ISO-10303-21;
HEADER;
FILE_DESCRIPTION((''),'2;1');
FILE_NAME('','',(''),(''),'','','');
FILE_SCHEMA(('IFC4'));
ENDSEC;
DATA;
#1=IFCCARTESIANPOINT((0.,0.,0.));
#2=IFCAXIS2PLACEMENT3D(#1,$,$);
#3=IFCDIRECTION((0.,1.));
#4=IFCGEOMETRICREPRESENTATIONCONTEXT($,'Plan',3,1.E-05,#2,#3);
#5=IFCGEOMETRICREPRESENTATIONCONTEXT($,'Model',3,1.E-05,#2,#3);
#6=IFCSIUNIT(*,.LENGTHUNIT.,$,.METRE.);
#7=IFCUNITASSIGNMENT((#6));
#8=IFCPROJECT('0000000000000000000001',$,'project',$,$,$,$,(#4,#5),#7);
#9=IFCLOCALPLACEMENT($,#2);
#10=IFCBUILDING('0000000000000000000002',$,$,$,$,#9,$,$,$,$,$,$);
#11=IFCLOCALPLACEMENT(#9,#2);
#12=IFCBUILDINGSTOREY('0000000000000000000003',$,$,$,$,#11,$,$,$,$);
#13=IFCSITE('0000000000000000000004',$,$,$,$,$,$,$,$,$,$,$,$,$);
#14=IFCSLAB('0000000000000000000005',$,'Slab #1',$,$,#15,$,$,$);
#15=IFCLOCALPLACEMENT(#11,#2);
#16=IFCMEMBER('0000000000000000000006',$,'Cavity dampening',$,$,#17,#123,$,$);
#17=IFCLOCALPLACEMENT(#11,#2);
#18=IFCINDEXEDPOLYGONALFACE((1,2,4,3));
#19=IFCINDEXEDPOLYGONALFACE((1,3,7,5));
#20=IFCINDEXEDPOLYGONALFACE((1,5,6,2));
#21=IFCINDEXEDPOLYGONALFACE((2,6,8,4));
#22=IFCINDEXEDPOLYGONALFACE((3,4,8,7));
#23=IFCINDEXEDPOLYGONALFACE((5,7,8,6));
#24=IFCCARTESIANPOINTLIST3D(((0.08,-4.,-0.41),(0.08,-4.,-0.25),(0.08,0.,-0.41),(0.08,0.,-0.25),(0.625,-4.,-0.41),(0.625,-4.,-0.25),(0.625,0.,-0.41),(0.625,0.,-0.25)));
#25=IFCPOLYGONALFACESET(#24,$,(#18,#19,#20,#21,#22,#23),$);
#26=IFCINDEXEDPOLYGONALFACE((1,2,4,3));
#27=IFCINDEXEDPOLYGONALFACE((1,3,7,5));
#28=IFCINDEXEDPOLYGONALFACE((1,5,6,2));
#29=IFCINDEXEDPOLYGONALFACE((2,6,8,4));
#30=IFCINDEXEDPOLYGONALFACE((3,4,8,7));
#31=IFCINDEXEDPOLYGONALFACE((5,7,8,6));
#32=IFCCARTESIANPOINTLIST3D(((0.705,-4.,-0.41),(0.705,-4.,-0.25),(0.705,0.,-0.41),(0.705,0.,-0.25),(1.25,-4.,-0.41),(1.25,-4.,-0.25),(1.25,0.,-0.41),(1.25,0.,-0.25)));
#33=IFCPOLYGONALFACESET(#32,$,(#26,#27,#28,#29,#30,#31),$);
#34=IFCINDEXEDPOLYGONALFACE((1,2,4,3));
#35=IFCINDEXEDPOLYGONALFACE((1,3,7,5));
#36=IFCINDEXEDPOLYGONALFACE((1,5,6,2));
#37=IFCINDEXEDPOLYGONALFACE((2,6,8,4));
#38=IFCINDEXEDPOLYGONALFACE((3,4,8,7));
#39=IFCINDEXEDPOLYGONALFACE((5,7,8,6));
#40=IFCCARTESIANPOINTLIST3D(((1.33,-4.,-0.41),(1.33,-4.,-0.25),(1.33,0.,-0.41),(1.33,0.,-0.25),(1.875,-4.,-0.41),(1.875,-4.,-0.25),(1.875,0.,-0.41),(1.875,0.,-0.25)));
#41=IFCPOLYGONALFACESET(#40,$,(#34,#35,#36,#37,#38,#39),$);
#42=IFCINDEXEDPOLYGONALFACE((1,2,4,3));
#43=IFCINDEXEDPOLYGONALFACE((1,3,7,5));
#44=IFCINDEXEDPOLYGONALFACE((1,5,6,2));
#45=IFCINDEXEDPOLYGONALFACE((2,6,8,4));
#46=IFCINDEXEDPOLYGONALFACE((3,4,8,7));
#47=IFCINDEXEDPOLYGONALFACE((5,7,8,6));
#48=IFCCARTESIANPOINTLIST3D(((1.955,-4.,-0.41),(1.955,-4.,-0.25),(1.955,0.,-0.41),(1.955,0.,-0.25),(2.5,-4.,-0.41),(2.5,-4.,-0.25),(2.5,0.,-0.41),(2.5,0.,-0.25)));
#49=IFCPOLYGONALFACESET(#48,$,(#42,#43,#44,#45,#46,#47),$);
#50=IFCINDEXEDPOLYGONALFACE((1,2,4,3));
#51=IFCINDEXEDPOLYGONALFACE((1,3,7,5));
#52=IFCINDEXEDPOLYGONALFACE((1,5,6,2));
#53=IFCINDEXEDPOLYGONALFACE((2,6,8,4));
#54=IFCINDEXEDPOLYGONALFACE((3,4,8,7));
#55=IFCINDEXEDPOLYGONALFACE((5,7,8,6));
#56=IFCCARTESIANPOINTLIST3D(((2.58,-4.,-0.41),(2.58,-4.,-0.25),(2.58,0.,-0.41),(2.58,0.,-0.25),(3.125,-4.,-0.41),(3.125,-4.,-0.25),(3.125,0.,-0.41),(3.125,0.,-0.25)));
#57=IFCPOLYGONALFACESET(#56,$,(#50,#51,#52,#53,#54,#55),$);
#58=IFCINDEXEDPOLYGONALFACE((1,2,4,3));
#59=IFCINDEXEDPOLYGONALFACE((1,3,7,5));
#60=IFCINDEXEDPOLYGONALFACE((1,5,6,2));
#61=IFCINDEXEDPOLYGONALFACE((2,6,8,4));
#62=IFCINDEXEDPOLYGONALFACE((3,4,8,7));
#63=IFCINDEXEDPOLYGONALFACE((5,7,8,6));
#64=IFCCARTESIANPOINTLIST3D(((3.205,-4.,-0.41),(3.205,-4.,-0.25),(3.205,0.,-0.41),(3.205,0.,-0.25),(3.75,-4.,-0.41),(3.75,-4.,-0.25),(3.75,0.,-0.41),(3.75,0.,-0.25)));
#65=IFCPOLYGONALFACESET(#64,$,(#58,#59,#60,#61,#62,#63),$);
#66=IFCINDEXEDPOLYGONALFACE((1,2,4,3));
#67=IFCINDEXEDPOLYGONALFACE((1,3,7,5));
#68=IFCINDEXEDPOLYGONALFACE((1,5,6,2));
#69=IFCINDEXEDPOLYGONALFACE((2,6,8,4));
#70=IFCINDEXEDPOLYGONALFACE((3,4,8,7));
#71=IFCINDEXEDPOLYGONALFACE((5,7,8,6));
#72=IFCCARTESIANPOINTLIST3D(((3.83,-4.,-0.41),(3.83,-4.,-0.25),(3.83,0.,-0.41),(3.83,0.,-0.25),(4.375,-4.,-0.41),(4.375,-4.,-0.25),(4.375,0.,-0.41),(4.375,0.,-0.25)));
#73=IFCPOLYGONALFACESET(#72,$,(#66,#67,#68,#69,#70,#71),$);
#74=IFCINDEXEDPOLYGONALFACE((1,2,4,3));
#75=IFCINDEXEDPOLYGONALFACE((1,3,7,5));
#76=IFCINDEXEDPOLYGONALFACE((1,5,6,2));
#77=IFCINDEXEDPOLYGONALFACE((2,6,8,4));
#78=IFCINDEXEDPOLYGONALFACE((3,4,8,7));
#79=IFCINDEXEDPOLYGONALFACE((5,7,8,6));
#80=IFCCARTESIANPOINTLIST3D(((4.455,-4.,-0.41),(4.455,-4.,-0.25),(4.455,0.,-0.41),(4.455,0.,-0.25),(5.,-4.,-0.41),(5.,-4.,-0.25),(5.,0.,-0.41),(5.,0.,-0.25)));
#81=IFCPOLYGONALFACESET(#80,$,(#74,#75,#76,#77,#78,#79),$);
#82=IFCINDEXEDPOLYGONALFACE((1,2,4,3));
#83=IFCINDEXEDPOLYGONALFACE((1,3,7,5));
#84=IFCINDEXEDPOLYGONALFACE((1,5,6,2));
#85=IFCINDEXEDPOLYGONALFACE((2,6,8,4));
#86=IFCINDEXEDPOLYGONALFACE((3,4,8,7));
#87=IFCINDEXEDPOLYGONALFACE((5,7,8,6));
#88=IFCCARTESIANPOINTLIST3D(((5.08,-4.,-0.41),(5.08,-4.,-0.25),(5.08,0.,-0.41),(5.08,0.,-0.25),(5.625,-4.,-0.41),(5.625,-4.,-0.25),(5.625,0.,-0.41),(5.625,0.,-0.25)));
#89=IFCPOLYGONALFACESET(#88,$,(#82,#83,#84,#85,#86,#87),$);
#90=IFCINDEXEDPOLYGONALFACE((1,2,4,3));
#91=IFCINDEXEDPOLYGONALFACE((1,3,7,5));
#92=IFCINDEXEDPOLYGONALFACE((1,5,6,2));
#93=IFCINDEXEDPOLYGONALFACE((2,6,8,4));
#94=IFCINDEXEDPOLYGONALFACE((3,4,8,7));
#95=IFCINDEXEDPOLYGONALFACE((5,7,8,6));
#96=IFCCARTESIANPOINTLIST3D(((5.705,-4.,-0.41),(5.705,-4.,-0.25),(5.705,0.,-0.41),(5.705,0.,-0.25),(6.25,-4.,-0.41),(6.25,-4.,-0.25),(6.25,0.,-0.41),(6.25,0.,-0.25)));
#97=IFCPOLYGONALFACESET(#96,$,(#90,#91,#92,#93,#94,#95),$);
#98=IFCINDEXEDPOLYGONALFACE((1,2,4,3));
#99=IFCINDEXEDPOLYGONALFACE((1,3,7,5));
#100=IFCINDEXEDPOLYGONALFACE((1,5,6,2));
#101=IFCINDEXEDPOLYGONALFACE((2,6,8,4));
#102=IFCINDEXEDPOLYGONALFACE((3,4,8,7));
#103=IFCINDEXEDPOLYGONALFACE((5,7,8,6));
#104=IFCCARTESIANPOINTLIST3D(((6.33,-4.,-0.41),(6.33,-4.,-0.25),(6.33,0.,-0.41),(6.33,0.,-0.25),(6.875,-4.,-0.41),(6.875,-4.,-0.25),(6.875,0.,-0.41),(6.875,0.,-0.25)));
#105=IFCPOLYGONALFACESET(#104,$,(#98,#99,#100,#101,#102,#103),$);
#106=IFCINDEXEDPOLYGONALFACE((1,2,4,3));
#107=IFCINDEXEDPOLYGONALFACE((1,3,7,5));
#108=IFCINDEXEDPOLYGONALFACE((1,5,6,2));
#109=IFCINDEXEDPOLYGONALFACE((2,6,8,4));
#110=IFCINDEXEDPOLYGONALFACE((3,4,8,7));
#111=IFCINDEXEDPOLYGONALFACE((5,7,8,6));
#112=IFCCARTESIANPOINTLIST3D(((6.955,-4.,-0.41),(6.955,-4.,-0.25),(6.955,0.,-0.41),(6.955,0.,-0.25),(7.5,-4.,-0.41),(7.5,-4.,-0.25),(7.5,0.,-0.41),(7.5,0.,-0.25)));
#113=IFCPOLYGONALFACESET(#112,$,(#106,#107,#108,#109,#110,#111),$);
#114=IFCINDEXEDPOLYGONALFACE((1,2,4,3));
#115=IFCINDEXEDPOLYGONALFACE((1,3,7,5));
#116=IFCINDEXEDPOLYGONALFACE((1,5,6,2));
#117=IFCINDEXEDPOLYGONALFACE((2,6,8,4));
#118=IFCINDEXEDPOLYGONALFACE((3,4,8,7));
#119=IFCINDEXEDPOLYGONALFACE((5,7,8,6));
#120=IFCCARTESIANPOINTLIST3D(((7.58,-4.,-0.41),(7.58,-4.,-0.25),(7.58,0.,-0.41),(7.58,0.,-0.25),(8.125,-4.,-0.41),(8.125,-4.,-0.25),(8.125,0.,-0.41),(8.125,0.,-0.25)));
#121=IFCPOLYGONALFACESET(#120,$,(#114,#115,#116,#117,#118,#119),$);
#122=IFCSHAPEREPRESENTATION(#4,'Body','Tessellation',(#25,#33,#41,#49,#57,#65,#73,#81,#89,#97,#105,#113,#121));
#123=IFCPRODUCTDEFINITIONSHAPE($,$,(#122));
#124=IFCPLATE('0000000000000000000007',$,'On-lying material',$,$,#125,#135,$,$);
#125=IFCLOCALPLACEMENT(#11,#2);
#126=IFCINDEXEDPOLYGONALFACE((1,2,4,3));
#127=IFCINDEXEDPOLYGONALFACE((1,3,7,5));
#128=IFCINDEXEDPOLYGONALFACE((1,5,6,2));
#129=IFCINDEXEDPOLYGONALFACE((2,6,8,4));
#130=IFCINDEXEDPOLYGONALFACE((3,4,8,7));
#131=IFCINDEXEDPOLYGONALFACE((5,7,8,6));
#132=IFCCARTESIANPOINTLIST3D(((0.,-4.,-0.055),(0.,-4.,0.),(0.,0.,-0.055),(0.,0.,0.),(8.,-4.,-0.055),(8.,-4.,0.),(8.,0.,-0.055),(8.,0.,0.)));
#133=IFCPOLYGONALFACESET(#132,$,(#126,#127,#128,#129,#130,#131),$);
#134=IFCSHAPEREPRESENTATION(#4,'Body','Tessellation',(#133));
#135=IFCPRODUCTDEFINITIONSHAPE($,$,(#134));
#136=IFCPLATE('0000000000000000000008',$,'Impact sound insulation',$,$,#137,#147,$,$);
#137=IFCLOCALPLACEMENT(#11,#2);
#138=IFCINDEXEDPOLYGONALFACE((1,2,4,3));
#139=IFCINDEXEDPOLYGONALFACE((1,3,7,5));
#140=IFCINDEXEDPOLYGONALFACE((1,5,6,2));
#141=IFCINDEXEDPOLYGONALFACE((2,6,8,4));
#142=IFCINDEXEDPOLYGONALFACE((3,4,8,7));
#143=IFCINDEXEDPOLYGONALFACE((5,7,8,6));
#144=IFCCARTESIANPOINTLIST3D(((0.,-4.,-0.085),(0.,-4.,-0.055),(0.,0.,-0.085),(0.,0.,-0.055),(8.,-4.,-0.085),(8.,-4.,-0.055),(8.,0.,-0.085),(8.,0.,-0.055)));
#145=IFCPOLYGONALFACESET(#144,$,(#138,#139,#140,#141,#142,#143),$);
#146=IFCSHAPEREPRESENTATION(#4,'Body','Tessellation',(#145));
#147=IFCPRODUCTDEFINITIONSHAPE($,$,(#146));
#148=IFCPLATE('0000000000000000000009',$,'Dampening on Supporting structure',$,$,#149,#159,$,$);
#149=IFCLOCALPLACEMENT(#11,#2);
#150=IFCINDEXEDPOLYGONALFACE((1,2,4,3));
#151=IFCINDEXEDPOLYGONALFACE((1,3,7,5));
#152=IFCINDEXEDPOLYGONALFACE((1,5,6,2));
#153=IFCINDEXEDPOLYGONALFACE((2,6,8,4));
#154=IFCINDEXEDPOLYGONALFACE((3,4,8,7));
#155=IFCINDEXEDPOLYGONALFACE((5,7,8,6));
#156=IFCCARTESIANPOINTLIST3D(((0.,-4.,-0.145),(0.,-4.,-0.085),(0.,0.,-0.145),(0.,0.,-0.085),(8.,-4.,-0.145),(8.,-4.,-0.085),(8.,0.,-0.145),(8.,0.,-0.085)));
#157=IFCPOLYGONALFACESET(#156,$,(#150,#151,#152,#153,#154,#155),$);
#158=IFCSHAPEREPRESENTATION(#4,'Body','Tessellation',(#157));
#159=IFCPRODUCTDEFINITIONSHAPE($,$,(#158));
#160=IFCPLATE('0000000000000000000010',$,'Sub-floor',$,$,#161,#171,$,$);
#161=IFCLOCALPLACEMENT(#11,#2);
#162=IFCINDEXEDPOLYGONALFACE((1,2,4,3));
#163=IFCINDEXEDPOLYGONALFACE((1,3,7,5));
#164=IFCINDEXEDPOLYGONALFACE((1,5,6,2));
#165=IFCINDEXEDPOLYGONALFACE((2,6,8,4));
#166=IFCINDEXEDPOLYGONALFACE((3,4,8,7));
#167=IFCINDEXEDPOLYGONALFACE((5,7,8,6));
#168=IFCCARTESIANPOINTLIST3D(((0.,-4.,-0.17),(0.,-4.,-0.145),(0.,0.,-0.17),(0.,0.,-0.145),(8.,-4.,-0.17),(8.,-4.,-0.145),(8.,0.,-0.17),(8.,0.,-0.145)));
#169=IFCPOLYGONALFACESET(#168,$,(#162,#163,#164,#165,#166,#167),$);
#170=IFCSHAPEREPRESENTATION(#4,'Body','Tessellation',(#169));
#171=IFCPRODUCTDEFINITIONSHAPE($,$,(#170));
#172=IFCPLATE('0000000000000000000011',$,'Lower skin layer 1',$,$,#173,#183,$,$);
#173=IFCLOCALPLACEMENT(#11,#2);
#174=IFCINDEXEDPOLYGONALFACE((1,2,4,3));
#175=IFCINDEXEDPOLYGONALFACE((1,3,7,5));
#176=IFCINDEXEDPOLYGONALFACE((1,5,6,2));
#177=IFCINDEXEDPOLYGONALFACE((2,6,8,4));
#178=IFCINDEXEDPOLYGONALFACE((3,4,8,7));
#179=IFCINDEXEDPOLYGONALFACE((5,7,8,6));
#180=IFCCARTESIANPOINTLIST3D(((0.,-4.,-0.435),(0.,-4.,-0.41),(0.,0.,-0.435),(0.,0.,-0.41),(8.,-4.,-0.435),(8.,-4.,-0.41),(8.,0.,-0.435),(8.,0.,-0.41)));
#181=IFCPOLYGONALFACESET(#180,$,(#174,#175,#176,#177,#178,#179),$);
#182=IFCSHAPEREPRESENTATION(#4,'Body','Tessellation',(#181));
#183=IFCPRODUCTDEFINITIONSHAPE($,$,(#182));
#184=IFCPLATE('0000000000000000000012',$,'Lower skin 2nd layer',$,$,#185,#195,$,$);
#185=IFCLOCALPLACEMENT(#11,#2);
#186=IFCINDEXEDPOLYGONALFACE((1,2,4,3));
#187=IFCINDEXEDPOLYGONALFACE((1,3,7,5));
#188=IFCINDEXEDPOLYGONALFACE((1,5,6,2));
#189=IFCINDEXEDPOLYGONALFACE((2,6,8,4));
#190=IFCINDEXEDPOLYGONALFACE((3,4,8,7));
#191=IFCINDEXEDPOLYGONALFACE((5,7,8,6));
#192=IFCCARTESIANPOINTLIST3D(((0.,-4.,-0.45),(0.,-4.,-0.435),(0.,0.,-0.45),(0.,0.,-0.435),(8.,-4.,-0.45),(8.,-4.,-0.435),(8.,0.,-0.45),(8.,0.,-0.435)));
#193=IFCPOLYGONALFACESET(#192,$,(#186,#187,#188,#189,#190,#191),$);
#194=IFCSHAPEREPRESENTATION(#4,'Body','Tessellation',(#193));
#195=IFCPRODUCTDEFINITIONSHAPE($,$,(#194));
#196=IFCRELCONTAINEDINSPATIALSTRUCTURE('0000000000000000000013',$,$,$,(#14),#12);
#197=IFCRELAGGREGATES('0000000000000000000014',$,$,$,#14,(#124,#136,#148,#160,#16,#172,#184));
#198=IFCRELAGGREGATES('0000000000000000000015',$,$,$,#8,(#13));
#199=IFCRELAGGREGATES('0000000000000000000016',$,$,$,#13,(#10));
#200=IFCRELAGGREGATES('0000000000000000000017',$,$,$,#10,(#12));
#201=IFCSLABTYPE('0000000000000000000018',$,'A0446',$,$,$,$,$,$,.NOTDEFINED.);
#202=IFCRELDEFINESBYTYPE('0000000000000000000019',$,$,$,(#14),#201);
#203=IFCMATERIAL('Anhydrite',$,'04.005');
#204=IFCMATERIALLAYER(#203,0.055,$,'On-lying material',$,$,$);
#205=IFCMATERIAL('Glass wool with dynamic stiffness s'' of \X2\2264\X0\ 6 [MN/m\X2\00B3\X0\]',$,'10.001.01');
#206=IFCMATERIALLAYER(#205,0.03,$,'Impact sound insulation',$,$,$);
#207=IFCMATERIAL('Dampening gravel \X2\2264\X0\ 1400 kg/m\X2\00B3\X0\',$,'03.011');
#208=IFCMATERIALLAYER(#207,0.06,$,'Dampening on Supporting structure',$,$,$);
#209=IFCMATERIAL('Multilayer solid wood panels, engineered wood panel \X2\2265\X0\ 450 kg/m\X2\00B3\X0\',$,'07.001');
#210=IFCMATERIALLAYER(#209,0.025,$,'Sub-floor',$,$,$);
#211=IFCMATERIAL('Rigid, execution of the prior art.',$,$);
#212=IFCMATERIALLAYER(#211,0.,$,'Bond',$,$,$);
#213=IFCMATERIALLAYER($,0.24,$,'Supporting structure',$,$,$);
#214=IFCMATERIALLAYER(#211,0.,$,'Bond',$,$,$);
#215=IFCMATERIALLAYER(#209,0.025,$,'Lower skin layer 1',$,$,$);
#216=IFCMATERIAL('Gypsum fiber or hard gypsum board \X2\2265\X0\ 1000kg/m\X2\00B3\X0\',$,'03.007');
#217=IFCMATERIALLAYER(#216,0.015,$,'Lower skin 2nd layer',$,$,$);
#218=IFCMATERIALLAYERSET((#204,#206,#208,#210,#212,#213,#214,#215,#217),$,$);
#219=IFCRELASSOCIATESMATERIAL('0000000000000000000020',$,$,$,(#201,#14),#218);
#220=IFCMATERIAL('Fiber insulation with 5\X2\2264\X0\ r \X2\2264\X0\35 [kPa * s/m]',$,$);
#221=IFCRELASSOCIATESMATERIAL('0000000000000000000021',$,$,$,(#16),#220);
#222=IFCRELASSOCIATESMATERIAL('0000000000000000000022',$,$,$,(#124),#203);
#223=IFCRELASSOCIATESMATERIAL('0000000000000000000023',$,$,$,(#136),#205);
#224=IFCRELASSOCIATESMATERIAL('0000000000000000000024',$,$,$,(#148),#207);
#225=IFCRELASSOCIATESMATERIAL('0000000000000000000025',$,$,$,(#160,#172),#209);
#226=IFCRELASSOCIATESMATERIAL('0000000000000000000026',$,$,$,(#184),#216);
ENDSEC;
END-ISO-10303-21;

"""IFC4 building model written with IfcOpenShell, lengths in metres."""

from ifc_helpers import new_model, si_unit, direction, frame, frame_2d, origin, origin_with_axes, place, context, project, spatial, rectangle, extrude, material, layer, layer_set, type_object, element, aggregate, save


model = new_model("IFC4")

# Units and contexts
plan_context = context("Plan", 3, precision=1e-05, world=origin(), true_north=direction((0.0, 1.0)))
model_context = context("Model", 3, precision=1e-05, world=origin(), true_north=direction((0.0, 1.0)))
ifc_project = project(units=[si_unit("LENGTHUNIT", "METRE")], contexts=[plan_context, model_context])

# Site, building, storey
site = spatial("IfcSite", under=ifc_project)
building_placement = place(None, origin())
building = spatial("IfcBuilding", under=site, at=building_placement)
storey_placement = place(building_placement, origin())
storey = spatial("IfcBuildingStorey", under=building, at=storey_placement)

# Slab, member, plates
ifc_material_1 = material(Name="Anhydrite", Category="04.005")
ifc_layer_1 = layer(ifc_material_1, 0.055, Name="On-lying material")
ifc_material_2 = material(Name="Glass wool with dynamic stiffness s' of ≤ 6 [MN/m³]", Category="10.001.01")
ifc_layer_2 = layer(ifc_material_2, 0.03, Name="Impact sound insulation")
ifc_material_3 = material(Name="Dampening gravel ≤ 1400 kg/m³", Category="03.011")
ifc_layer_3 = layer(ifc_material_3, 0.06, Name="Dampening on Supporting structure")
ifc_material_4 = material(Name="Multilayer solid wood panels, engineered wood panel ≥ 450 kg/m³", Category="07.001")
ifc_layer_4 = layer(ifc_material_4, 0.025, Name="Sub-floor")
ifc_material_5 = material(Name="Rigid, execution of the prior art.")
ifc_layer_5 = layer(ifc_material_5, 0.0, Name="Bond")
ifc_layer_6 = layer(None, 0.24, Name="Supporting structure")
ifc_layer_7 = layer(ifc_material_5, 0.0, Name="Bond")
ifc_layer_8 = layer(ifc_material_4, 0.025, Name="Lower skin layer 1")
ifc_material_6 = material(Name="Gypsum fiber or hard gypsum board ≥ 1000kg/m³", Category="03.007")
ifc_layer_9 = layer(ifc_material_6, 0.015, Name="Lower skin 2nd layer")
ifc_layer_set = layer_set([ifc_layer_1, ifc_layer_2, ifc_layer_3, ifc_layer_4, ifc_layer_5, ifc_layer_6, ifc_layer_7, ifc_layer_8, ifc_layer_9])
slab_type = type_object("IfcSlabType", Name="A0446", PredefinedType="NOTDEFINED", material=ifc_layer_set)
slab_placement = place(None, frame((0.0, 0.0, 0.0), z_axis=(0.0, 0.0, -1.0), x_axis=(1.0, 0.0, 0.0)))
slab = element("IfcSlab", 1, at=slab_placement, inside=storey, type_object=slab_type, material=ifc_layer_set, Name="Slab #1")
ifc_material_7 = material(Name="Fiber insulation with 5≤ r ≤35 [kPa * s/m]")
member_1_placement = place(slab_placement, origin())
member_1 = element("IfcMember", 2, at=member_1_placement, material=ifc_material_7, Name="Cavity dampening", context=plan_context, shape_type="SweptSolid", body=[
    extrude(rectangle(XDim=0.545, YDim=0.16, at=frame_2d((0.2725, 0.08), x_axis=(1.0, 0.0))), frame((0.08, 4.0, 0.25), z_axis=(0.0, -1.0, 0.0), x_axis=(1.0, 0.0, 0.0)), (0.0, 0.0, 1.0), 4.0),
    extrude(rectangle(XDim=0.545, YDim=0.16, at=frame_2d((0.2725, 0.08), x_axis=(1.0, 0.0))), frame((0.705, 4.0, 0.25), z_axis=(0.0, -1.0, 0.0), x_axis=(1.0, 0.0, 0.0)), (0.0, 0.0, 1.0), 4.0),
    extrude(rectangle(XDim=0.545, YDim=0.16, at=frame_2d((0.2725, 0.08), x_axis=(1.0, 0.0))), frame((1.33, 4.0, 0.25), z_axis=(0.0, -1.0, 0.0), x_axis=(1.0, 0.0, 0.0)), (0.0, 0.0, 1.0), 4.0),
    extrude(rectangle(XDim=0.545, YDim=0.16, at=frame_2d((0.2725, 0.08), x_axis=(1.0, 0.0))), frame((1.955, 4.0, 0.25), z_axis=(0.0, -1.0, 0.0), x_axis=(1.0, 0.0, 0.0)), (0.0, 0.0, 1.0), 4.0),
    extrude(rectangle(XDim=0.545, YDim=0.16, at=frame_2d((0.2725, 0.08), x_axis=(1.0, 0.0))), frame((2.58, 4.0, 0.25), z_axis=(0.0, -1.0, 0.0), x_axis=(1.0, 0.0, 0.0)), (0.0, 0.0, 1.0), 4.0),
    extrude(rectangle(XDim=0.545, YDim=0.16, at=frame_2d((0.2725, 0.08), x_axis=(1.0, 0.0))), frame((3.205, 4.0, 0.25), z_axis=(0.0, -1.0, 0.0), x_axis=(1.0, 0.0, 0.0)), (0.0, 0.0, 1.0), 4.0),
    extrude(rectangle(XDim=0.545, YDim=0.16, at=frame_2d((0.2725, 0.08), x_axis=(1.0, 0.0))), frame((3.83, 4.0, 0.25), z_axis=(0.0, -1.0, 0.0), x_axis=(1.0, 0.0, 0.0)), (0.0, 0.0, 1.0), 4.0),
    extrude(rectangle(XDim=0.545, YDim=0.16, at=frame_2d((0.2725, 0.08), x_axis=(1.0, 0.0))), frame((4.455, 4.0, 0.25), z_axis=(0.0, -1.0, 0.0), x_axis=(1.0, 0.0, 0.0)), (0.0, 0.0, 1.0), 4.0),
    extrude(rectangle(XDim=0.545, YDim=0.16, at=frame_2d((0.2725, 0.08), x_axis=(1.0, 0.0))), frame((5.08, 4.0, 0.25), z_axis=(0.0, -1.0, 0.0), x_axis=(1.0, 0.0, 0.0)), (0.0, 0.0, 1.0), 4.0),
    extrude(rectangle(XDim=0.545, YDim=0.16, at=frame_2d((0.2725, 0.08), x_axis=(1.0, 0.0))), frame((5.705, 4.0, 0.25), z_axis=(0.0, -1.0, 0.0), x_axis=(1.0, 0.0, 0.0)), (0.0, 0.0, 1.0), 4.0),
    extrude(rectangle(XDim=0.545, YDim=0.16, at=frame_2d((0.2725, 0.08), x_axis=(1.0, 0.0))), frame((6.33, 4.0, 0.25), z_axis=(0.0, -1.0, 0.0), x_axis=(1.0, 0.0, 0.0)), (0.0, 0.0, 1.0), 4.0),
    extrude(rectangle(XDim=0.545, YDim=0.16, at=frame_2d((0.2725, 0.08), x_axis=(1.0, 0.0))), frame((6.955, 4.0, 0.25), z_axis=(0.0, -1.0, 0.0), x_axis=(1.0, 0.0, 0.0)), (0.0, 0.0, 1.0), 4.0),
    extrude(rectangle(XDim=0.545, YDim=0.16, at=frame_2d((0.2725, 0.08), x_axis=(1.0, 0.0))), frame((7.58, 4.0, 0.25), z_axis=(0.0, -1.0, 0.0), x_axis=(1.0, 0.0, 0.0)), (0.0, 0.0, 1.0), 4.0),
])
plate_1_placement = place(slab_placement, origin())
plate_1 = element("IfcPlate", 3, at=plate_1_placement, material=ifc_material_1, Name="On-lying material", context=plan_context, shape_type="SweptSolid", body=[
    extrude(rectangle(XDim=8.0, YDim=4.0, at=frame_2d((4.0, 2.0), x_axis=(1.0, 0.0))), origin_with_axes(), (0.0, 0.0, 1.0), 0.055),
])
plate_2_placement = place(slab_placement, origin())
plate_2 = element("IfcPlate", 4, at=plate_2_placement, material=ifc_material_2, Name="Impact sound insulation", context=plan_context, shape_type="SweptSolid", body=[
    extrude(rectangle(XDim=8.0, YDim=4.0, at=frame_2d((4.0, 2.0), x_axis=(1.0, 0.0))), frame((0.0, 0.0, 0.055), z_axis=(0.0, 0.0, 1.0), x_axis=(1.0, 0.0, 0.0)), (0.0, 0.0, 1.0), 0.03),
])
plate_3_placement = place(slab_placement, origin())
plate_3 = element("IfcPlate", 5, at=plate_3_placement, material=ifc_material_3, Name="Dampening on Supporting structure", context=plan_context, shape_type="SweptSolid", body=[
    extrude(rectangle(XDim=8.0, YDim=4.0, at=frame_2d((4.0, 2.0), x_axis=(1.0, 0.0))), frame((0.0, 0.0, 0.085), z_axis=(0.0, 0.0, 1.0), x_axis=(1.0, 0.0, 0.0)), (0.0, 0.0, 1.0), 0.06),
])
plate_4_placement = place(slab_placement, origin())
plate_4 = element("IfcPlate", 6, at=plate_4_placement, material=ifc_material_4, Name="Sub-floor", context=plan_context, shape_type="SweptSolid", body=[
    extrude(rectangle(XDim=8.0, YDim=4.0, at=frame_2d((4.0, 2.0), x_axis=(1.0, 0.0))), frame((0.0, 0.0, 0.145), z_axis=(0.0, 0.0, 1.0), x_axis=(1.0, 0.0, 0.0)), (0.0, 0.0, 1.0), 0.025),
])
plate_5_placement = place(slab_placement, origin())
plate_5 = element("IfcPlate", 7, at=plate_5_placement, material=ifc_material_4, Name="Lower skin layer 1", context=plan_context, shape_type="SweptSolid", body=[
    extrude(rectangle(XDim=8.0, YDim=4.0, at=frame_2d((4.0, 2.0), x_axis=(1.0, 0.0))), frame((0.0, 0.0, 0.41), z_axis=(0.0, 0.0, 1.0), x_axis=(1.0, 0.0, 0.0)), (0.0, 0.0, 1.0), 0.025),
])
plate_6_placement = place(slab_placement, origin())
plate_6 = element("IfcPlate", 8, at=plate_6_placement, material=ifc_material_6, Name="Lower skin 2nd layer", context=plan_context, shape_type="SweptSolid", body=[
    extrude(rectangle(XDim=8.0, YDim=4.0, at=frame_2d((4.0, 2.0), x_axis=(1.0, 0.0))), frame((0.0, 0.0, 0.435), z_axis=(0.0, 0.0, 1.0), x_axis=(1.0, 0.0, 0.0)), (0.0, 0.0, 1.0), 0.015),
])
aggregate(slab, [plate_1, plate_2, plate_3, plate_4, member_1, plate_5, plate_6])

save(model, "model.ifc")
